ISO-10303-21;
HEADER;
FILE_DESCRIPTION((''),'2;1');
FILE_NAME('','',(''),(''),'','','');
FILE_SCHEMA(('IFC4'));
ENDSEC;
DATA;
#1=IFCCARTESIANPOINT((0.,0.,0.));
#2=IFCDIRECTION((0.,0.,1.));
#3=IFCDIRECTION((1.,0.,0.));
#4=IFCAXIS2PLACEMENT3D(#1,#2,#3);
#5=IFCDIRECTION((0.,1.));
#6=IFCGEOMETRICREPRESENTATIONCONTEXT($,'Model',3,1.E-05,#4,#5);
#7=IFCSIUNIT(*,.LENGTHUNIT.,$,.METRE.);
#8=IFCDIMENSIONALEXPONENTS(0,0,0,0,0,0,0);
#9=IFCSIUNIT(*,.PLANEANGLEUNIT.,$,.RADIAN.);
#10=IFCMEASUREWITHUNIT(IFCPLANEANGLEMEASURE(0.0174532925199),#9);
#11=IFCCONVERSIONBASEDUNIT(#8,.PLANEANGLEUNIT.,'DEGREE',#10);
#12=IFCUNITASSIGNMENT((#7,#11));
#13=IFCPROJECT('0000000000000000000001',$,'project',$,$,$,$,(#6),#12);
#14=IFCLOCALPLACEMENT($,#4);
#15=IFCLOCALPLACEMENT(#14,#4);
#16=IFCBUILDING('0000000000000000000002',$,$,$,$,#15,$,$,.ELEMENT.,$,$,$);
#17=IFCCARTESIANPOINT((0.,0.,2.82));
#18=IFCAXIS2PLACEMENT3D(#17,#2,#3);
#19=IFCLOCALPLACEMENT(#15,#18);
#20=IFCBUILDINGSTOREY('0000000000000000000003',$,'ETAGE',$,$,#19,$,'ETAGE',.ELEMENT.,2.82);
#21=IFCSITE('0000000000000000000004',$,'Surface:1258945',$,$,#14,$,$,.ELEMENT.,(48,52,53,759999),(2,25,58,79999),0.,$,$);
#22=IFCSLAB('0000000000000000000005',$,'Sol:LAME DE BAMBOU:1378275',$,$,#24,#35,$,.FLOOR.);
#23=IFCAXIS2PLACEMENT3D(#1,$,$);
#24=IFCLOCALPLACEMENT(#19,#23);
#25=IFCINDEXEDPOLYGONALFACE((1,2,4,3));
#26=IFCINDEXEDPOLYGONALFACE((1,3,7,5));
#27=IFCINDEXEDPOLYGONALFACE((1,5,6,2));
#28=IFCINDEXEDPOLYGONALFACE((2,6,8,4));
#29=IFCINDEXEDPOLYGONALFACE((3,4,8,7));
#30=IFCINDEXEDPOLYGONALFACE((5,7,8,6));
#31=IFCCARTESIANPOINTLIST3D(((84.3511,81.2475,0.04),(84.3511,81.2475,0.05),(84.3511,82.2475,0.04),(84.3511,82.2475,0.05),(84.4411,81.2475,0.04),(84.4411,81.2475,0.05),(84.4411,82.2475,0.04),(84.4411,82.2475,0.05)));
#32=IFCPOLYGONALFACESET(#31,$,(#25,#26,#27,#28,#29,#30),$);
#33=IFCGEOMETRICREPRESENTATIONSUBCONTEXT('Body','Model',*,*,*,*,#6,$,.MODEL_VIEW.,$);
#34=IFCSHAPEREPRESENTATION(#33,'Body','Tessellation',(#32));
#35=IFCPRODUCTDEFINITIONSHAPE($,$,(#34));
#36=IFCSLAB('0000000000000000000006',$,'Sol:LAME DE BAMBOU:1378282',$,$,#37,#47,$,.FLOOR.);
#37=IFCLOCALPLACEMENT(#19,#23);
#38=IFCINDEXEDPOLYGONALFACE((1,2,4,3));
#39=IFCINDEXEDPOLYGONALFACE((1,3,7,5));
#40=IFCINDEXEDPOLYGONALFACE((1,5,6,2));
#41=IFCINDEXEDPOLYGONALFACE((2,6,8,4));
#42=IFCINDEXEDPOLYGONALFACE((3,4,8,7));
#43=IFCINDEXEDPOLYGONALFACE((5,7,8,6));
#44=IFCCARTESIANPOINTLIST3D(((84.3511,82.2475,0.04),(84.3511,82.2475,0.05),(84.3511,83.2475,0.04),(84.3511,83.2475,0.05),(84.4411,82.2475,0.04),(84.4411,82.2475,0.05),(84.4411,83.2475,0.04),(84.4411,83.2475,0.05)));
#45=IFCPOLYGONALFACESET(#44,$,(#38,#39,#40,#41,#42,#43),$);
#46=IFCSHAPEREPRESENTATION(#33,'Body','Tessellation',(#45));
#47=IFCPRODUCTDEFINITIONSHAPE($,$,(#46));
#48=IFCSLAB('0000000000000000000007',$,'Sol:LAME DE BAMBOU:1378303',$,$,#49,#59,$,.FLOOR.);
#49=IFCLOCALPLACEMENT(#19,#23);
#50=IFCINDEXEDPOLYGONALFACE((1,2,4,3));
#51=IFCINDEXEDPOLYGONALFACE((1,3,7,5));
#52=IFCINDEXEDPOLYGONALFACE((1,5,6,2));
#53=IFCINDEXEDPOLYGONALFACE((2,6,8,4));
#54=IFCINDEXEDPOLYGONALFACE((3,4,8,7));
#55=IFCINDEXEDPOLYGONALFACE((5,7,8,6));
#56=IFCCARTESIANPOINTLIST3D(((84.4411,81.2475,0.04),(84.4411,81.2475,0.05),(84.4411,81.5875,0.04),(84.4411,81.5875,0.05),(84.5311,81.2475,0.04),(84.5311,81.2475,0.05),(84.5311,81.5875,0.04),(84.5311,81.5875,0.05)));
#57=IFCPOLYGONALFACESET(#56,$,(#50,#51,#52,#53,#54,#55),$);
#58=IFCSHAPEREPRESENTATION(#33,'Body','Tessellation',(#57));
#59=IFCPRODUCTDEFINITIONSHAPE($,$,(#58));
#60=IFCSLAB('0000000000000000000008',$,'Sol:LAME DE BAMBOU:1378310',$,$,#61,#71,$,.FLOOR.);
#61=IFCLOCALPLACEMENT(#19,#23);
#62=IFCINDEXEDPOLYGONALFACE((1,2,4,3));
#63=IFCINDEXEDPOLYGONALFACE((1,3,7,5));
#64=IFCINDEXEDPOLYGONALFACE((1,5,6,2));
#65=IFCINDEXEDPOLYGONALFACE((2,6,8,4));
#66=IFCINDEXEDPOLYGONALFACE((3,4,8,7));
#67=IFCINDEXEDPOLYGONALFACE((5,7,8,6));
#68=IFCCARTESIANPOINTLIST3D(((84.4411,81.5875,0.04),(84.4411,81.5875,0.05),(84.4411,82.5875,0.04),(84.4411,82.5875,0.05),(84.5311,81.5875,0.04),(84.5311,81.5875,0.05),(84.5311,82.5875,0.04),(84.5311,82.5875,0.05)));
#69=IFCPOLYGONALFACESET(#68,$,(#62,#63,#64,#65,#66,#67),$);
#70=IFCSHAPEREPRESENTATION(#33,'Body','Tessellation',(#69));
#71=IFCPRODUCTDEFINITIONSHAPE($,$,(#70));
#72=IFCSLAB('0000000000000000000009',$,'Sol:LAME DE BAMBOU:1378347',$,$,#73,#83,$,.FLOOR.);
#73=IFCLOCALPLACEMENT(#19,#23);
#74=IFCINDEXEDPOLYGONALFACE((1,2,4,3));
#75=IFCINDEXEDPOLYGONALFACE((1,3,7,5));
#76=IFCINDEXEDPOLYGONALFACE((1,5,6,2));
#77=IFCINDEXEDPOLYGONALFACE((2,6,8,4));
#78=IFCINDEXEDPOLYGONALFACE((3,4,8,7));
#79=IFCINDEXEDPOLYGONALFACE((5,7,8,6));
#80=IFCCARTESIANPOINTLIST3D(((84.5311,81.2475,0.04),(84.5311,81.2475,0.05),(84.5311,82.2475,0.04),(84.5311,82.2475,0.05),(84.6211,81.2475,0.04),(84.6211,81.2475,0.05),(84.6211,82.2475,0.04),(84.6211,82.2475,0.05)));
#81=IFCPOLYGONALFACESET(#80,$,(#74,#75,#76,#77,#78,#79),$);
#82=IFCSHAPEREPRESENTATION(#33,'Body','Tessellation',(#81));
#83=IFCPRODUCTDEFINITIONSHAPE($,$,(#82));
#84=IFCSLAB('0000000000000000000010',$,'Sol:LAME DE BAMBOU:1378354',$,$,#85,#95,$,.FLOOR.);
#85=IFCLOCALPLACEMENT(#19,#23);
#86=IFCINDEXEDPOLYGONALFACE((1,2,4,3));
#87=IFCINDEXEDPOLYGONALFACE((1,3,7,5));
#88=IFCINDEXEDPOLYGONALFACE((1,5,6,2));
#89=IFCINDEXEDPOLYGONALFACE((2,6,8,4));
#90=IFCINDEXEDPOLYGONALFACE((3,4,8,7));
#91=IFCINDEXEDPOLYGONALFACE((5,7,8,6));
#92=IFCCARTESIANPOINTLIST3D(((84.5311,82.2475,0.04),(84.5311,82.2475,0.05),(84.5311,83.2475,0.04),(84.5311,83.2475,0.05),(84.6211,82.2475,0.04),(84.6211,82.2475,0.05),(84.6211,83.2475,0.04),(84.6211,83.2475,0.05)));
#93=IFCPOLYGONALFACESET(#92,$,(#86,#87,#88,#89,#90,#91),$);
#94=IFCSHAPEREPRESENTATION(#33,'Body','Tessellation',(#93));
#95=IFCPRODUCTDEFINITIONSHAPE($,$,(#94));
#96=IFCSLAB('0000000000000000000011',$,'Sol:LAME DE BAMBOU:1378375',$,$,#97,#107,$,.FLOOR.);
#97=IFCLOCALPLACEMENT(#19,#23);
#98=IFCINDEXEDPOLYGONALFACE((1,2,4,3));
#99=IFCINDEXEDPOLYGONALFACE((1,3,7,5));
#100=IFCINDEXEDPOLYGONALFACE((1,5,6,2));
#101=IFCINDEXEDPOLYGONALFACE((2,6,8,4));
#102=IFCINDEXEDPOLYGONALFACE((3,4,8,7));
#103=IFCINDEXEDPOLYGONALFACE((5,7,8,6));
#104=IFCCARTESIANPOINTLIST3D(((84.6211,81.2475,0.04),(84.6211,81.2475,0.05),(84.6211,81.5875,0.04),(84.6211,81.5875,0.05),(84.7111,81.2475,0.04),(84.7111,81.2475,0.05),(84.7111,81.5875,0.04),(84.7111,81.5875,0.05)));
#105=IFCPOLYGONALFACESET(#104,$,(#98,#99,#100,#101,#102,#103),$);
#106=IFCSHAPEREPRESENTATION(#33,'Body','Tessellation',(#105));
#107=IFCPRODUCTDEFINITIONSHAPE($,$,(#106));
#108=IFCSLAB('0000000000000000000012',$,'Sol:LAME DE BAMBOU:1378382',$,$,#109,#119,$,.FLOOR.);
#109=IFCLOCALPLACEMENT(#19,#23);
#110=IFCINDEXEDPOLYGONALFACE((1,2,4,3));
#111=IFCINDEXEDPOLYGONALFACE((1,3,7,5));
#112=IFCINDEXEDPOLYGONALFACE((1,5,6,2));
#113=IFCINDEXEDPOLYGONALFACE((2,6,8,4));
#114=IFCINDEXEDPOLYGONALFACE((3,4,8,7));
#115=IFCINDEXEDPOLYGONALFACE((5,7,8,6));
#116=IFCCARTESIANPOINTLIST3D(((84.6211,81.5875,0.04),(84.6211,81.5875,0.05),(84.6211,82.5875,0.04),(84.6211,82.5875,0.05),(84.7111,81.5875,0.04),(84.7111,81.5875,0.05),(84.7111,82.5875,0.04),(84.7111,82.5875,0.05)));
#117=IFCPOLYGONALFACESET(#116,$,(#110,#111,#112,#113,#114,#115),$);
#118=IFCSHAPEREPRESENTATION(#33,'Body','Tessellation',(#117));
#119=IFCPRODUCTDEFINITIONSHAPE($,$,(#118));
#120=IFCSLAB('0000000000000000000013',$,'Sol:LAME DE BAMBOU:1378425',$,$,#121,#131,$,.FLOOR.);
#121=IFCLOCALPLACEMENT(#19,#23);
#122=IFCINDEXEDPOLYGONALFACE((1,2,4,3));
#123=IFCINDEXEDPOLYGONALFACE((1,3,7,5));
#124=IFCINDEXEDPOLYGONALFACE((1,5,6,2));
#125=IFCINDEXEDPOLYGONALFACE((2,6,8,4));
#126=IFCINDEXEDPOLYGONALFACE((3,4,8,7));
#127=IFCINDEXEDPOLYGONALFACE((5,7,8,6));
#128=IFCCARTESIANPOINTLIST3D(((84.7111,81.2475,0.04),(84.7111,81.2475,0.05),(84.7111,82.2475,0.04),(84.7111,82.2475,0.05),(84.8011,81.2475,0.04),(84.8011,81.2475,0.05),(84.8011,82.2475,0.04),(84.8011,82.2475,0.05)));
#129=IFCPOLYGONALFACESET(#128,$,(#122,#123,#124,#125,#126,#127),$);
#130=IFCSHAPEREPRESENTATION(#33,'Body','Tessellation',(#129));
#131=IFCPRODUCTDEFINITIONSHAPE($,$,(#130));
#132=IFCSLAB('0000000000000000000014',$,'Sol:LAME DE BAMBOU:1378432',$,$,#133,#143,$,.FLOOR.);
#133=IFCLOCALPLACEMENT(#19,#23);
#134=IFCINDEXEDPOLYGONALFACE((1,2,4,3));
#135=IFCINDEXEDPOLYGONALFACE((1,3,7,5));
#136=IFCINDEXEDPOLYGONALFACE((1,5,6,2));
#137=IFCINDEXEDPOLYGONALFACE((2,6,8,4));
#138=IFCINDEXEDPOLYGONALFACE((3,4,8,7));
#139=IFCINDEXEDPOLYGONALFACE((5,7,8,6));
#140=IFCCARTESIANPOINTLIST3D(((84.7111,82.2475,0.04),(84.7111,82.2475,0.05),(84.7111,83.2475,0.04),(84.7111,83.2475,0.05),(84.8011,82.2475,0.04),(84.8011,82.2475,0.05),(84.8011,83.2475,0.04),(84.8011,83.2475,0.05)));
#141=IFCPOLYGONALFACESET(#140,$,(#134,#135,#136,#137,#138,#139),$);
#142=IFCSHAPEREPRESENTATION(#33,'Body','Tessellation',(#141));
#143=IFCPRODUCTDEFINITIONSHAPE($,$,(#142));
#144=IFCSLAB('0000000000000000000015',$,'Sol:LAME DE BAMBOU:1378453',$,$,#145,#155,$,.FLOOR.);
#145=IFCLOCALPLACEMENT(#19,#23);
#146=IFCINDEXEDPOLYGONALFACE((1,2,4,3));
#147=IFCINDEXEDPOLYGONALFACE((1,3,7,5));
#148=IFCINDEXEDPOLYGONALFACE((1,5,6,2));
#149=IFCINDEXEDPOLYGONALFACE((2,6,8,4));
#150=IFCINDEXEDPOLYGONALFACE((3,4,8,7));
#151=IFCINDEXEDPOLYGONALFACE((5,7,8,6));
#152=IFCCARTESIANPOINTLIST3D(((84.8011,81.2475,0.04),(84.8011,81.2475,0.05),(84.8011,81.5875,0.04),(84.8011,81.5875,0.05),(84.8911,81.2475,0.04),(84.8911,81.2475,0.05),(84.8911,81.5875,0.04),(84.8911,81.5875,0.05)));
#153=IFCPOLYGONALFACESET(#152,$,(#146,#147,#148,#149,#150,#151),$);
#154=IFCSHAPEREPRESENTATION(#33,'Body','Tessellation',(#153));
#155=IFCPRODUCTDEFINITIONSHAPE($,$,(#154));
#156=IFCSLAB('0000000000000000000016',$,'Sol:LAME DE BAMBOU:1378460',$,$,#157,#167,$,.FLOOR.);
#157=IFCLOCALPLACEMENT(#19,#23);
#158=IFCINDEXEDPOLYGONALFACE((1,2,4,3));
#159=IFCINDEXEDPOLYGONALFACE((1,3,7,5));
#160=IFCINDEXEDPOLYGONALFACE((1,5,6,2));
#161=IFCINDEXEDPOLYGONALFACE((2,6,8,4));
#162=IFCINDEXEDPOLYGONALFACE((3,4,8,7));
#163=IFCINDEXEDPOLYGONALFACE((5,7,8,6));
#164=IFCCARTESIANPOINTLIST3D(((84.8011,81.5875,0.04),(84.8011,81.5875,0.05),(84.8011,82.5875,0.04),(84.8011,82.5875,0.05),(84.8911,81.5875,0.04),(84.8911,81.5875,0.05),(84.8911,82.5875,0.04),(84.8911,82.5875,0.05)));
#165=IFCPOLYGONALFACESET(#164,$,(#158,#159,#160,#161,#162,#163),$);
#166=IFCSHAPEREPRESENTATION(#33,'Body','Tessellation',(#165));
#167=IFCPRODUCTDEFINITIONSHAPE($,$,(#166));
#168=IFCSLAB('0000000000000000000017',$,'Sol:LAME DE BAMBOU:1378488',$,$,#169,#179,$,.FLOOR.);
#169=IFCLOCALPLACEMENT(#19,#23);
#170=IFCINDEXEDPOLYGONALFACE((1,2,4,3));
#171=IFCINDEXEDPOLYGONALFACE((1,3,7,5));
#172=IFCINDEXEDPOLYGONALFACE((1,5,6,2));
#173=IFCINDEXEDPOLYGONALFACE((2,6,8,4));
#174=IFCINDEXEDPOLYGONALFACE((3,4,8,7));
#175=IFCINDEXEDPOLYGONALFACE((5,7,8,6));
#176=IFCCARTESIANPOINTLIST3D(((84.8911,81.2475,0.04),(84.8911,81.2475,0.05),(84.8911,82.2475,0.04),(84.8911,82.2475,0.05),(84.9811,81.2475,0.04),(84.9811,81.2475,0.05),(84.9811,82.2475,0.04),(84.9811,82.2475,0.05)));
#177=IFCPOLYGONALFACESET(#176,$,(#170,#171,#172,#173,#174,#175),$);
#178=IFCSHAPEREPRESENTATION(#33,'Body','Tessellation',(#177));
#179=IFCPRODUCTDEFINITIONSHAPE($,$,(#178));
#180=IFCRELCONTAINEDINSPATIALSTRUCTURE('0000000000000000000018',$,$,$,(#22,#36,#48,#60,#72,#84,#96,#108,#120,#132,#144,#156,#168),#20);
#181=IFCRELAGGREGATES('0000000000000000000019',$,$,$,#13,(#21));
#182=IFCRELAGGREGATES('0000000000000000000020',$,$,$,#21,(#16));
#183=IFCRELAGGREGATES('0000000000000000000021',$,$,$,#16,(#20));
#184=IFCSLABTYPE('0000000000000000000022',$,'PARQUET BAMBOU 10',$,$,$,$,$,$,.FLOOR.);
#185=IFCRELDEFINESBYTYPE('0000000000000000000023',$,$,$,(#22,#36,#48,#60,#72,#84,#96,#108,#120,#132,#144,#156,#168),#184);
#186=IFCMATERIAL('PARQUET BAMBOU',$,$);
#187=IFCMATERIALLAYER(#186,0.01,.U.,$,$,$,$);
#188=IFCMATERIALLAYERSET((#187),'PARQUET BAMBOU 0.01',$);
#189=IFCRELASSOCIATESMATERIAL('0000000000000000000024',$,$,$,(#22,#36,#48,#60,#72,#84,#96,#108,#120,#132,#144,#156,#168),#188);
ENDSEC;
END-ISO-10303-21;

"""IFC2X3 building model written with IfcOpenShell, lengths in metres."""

from ifc_helpers import new_model, entity, si_unit, converted_unit, direction, frame, origin_with_axes, place, context, subcontext, project, spatial, polyline, outline, extrude, material, layer, layer_set, layer_usage, type_object, element, save


model = new_model("IFC2X3")

# Units and contexts
model_context = context("Model", 3, precision=1e-05, world=origin_with_axes(), true_north=direction((0.0, 1.0)))
body_context = subcontext(model_context, "Body", "Model", "MODEL_VIEW")
ifc_project = project(units=[si_unit("LENGTHUNIT", "METRE"), converted_unit("PLANEANGLEUNIT", "DEGREE", entity("IfcPlaneAngleMeasure", 0.0174532925199), si_unit("PLANEANGLEUNIT", "RADIAN"), dimensions=[0, 0, 0, 0, 0, 0, 0])], contexts=[model_context])

# Site, building, storey
site_placement = place(None, origin_with_axes())
site = spatial("IfcSite", under=ifc_project, at=site_placement, Name="Surface:1258945", CompositionType="ELEMENT", RefLatitude=(48, 52, 53, 759999), RefLongitude=(2, 25, 58, 79999), RefElevation=0.0)
building_placement = place(site_placement, origin_with_axes())
building = spatial("IfcBuilding", under=site, at=building_placement, CompositionType="ELEMENT")
storey_placement = place(building_placement, frame((0.0, 0.0, 2.82), z_axis=(0.0, 0.0, 1.0), x_axis=(1.0, 0.0, 0.0)))
storey = spatial("IfcBuildingStorey", under=building, at=storey_placement, Name="ETAGE", LongName="ETAGE", CompositionType="ELEMENT", Elevation=2.82)

# Slabs
ifc_material = material(Name="PARQUET BAMBOU")
ifc_layer = layer(ifc_material, 0.01, ventilated="UNKNOWN")
ifc_layer_set = layer_set([ifc_layer], Name="PARQUET BAMBOU 0.01")
ifc_layer_usage_1 = layer_usage(ifc_layer_set, "AXIS3", "NEGATIVE", 0.01)
slab_type = type_object("IfcSlabType", Name="PARQUET BAMBOU 10", PredefinedType="FLOOR")
slab_1_placement = place(storey_placement, frame((84.3511, 82.2475, 0.05), z_axis=(0.0, 0.0, 1.0), x_axis=(1.0, 0.0, 0.0)))
element("IfcSlab", 1, at=slab_1_placement, inside=storey, type_object=slab_type, material=ifc_layer_usage_1, Name="Sol:LAME DE BAMBOU:1378275", PredefinedType="FLOOR", context=body_context, shape_type="SweptSolid", body=[
    extrude(outline(polyline([(0.0, 0.0), (0.0, -1.0), (0.09, -1.0), (0.09, 0.0), (0.0, 0.0)])), frame((0.0, 0.0, -0.01), z_axis=(0.0, 0.0, 1.0), x_axis=(1.0, 0.0, 0.0)), (0.0, 0.0, 1.0), 0.01),
])
ifc_layer_usage_2 = layer_usage(ifc_layer_set, "AXIS3", "NEGATIVE", 0.01)
slab_2_placement = place(storey_placement, frame((84.3511, 83.2475, 0.05), z_axis=(0.0, 0.0, 1.0), x_axis=(1.0, 0.0, 0.0)))
element("IfcSlab", 2, at=slab_2_placement, inside=storey, type_object=slab_type, material=ifc_layer_usage_2, Name="Sol:LAME DE BAMBOU:1378282", PredefinedType="FLOOR", context=body_context, shape_type="SweptSolid", body=[
    extrude(outline(polyline([(0.0, 0.0), (0.0, -1.0), (0.09, -1.0), (0.09, 0.0), (0.0, 0.0)])), frame((0.0, 0.0, -0.01), z_axis=(0.0, 0.0, 1.0), x_axis=(1.0, 0.0, 0.0)), (0.0, 0.0, 1.0), 0.01),
])
ifc_layer_usage_3 = layer_usage(ifc_layer_set, "AXIS3", "NEGATIVE", 0.01)
slab_3_placement = place(storey_placement, frame((84.4411, 81.5875, 0.05), z_axis=(0.0, 0.0, 1.0), x_axis=(1.0, 0.0, 0.0)))
element("IfcSlab", 3, at=slab_3_placement, inside=storey, type_object=slab_type, material=ifc_layer_usage_3, Name="Sol:LAME DE BAMBOU:1378303", PredefinedType="FLOOR", context=body_context, shape_type="SweptSolid", body=[
    extrude(outline(polyline([(0.0, 0.0), (0.0, -0.34), (0.09, -0.34), (0.09, 0.0), (0.0, 0.0)])), frame((0.0, 0.0, -0.01), z_axis=(0.0, 0.0, 1.0), x_axis=(1.0, 0.0, 0.0)), (0.0, 0.0, 1.0), 0.01),
])
ifc_layer_usage_4 = layer_usage(ifc_layer_set, "AXIS3", "NEGATIVE", 0.01)
slab_4_placement = place(storey_placement, frame((84.4411, 82.5875, 0.05), z_axis=(0.0, 0.0, 1.0), x_axis=(1.0, 0.0, 0.0)))
element("IfcSlab", 4, at=slab_4_placement, inside=storey, type_object=slab_type, material=ifc_layer_usage_4, Name="Sol:LAME DE BAMBOU:1378310", PredefinedType="FLOOR", context=body_context, shape_type="SweptSolid", body=[
    extrude(outline(polyline([(0.0, 0.0), (0.0, -1.0), (0.09, -1.0), (0.09, 0.0), (0.0, 0.0)])), frame((0.0, 0.0, -0.01), z_axis=(0.0, 0.0, 1.0), x_axis=(1.0, 0.0, 0.0)), (0.0, 0.0, 1.0), 0.01),
])
ifc_layer_usage_5 = layer_usage(ifc_layer_set, "AXIS3", "NEGATIVE", 0.01)
slab_5_placement = place(storey_placement, frame((84.5311, 82.2475, 0.05), z_axis=(0.0, 0.0, 1.0), x_axis=(1.0, 0.0, 0.0)))
element("IfcSlab", 5, at=slab_5_placement, inside=storey, type_object=slab_type, material=ifc_layer_usage_5, Name="Sol:LAME DE BAMBOU:1378347", PredefinedType="FLOOR", context=body_context, shape_type="SweptSolid", body=[
    extrude(outline(polyline([(0.0, 0.0), (0.0, -1.0), (0.09, -1.0), (0.09, 0.0), (0.0, 0.0)])), frame((0.0, 0.0, -0.01), z_axis=(0.0, 0.0, 1.0), x_axis=(1.0, 0.0, 0.0)), (0.0, 0.0, 1.0), 0.01),
])
ifc_layer_usage_6 = layer_usage(ifc_layer_set, "AXIS3", "NEGATIVE", 0.01)
slab_6_placement = place(storey_placement, frame((84.5311, 83.2475, 0.05), z_axis=(0.0, 0.0, 1.0), x_axis=(1.0, 0.0, 0.0)))
element("IfcSlab", 6, at=slab_6_placement, inside=storey, type_object=slab_type, material=ifc_layer_usage_6, Name="Sol:LAME DE BAMBOU:1378354", PredefinedType="FLOOR", context=body_context, shape_type="SweptSolid", body=[
    extrude(outline(polyline([(0.0, 0.0), (0.0, -1.0), (0.09, -1.0), (0.09, 0.0), (0.0, 0.0)])), frame((0.0, 0.0, -0.01), z_axis=(0.0, 0.0, 1.0), x_axis=(1.0, 0.0, 0.0)), (0.0, 0.0, 1.0), 0.01),
])
ifc_layer_usage_7 = layer_usage(ifc_layer_set, "AXIS3", "NEGATIVE", 0.01)
slab_7_placement = place(storey_placement, frame((84.6211, 81.5875, 0.05), z_axis=(0.0, 0.0, 1.0), x_axis=(1.0, 0.0, 0.0)))
element("IfcSlab", 7, at=slab_7_placement, inside=storey, type_object=slab_type, material=ifc_layer_usage_7, Name="Sol:LAME DE BAMBOU:1378375", PredefinedType="FLOOR", context=body_context, shape_type="SweptSolid", body=[
    extrude(outline(polyline([(0.0, 0.0), (0.0, -0.34), (0.09, -0.34), (0.09, 0.0), (0.0, 0.0)])), frame((0.0, 0.0, -0.01), z_axis=(0.0, 0.0, 1.0), x_axis=(1.0, 0.0, 0.0)), (0.0, 0.0, 1.0), 0.01),
])
ifc_layer_usage_8 = layer_usage(ifc_layer_set, "AXIS3", "NEGATIVE", 0.01)
slab_8_placement = place(storey_placement, frame((84.6211, 82.5875, 0.05), z_axis=(0.0, 0.0, 1.0), x_axis=(1.0, 0.0, 0.0)))
element("IfcSlab", 8, at=slab_8_placement, inside=storey, type_object=slab_type, material=ifc_layer_usage_8, Name="Sol:LAME DE BAMBOU:1378382", PredefinedType="FLOOR", context=body_context, shape_type="SweptSolid", body=[
    extrude(outline(polyline([(0.0, 0.0), (0.0, -1.0), (0.09, -1.0), (0.09, 0.0), (0.0, 0.0)])), frame((0.0, 0.0, -0.01), z_axis=(0.0, 0.0, 1.0), x_axis=(1.0, 0.0, 0.0)), (0.0, 0.0, 1.0), 0.01),
])
ifc_layer_usage_9 = layer_usage(ifc_layer_set, "AXIS3", "NEGATIVE", 0.01)
slab_9_placement = place(storey_placement, frame((84.7111, 82.2475, 0.05), z_axis=(0.0, 0.0, 1.0), x_axis=(1.0, 0.0, 0.0)))
element("IfcSlab", 9, at=slab_9_placement, inside=storey, type_object=slab_type, material=ifc_layer_usage_9, Name="Sol:LAME DE BAMBOU:1378425", PredefinedType="FLOOR", context=body_context, shape_type="SweptSolid", body=[
    extrude(outline(polyline([(0.0, 0.0), (0.0, -1.0), (0.09, -1.0), (0.09, 0.0), (0.0, 0.0)])), frame((0.0, 0.0, -0.01), z_axis=(0.0, 0.0, 1.0), x_axis=(1.0, 0.0, 0.0)), (0.0, 0.0, 1.0), 0.01),
])
ifc_layer_usage_10 = layer_usage(ifc_layer_set, "AXIS3", "NEGATIVE", 0.01)
slab_10_placement = place(storey_placement, frame((84.7111, 83.2475, 0.05), z_axis=(0.0, 0.0, 1.0), x_axis=(1.0, 0.0, 0.0)))
element("IfcSlab", 10, at=slab_10_placement, inside=storey, type_object=slab_type, material=ifc_layer_usage_10, Name="Sol:LAME DE BAMBOU:1378432", PredefinedType="FLOOR", context=body_context, shape_type="SweptSolid", body=[
    extrude(outline(polyline([(0.0, 0.0), (0.0, -1.0), (0.09, -1.0), (0.09, 0.0), (0.0, 0.0)])), frame((0.0, 0.0, -0.01), z_axis=(0.0, 0.0, 1.0), x_axis=(1.0, 0.0, 0.0)), (0.0, 0.0, 1.0), 0.01),
])
ifc_layer_usage_11 = layer_usage(ifc_layer_set, "AXIS3", "NEGATIVE", 0.01)
slab_11_placement = place(storey_placement, frame((84.8011, 81.5875, 0.05), z_axis=(0.0, 0.0, 1.0), x_axis=(1.0, 0.0, 0.0)))
element("IfcSlab", 11, at=slab_11_placement, inside=storey, type_object=slab_type, material=ifc_layer_usage_11, Name="Sol:LAME DE BAMBOU:1378453", PredefinedType="FLOOR", context=body_context, shape_type="SweptSolid", body=[
    extrude(outline(polyline([(0.0, 0.0), (0.0, -0.34), (0.09, -0.34), (0.09, 0.0), (0.0, 0.0)])), frame((0.0, 0.0, -0.01), z_axis=(0.0, 0.0, 1.0), x_axis=(1.0, 0.0, 0.0)), (0.0, 0.0, 1.0), 0.01),
])
ifc_layer_usage_12 = layer_usage(ifc_layer_set, "AXIS3", "NEGATIVE", 0.01)
slab_12_placement = place(storey_placement, frame((84.8011, 82.5875, 0.05), z_axis=(0.0, 0.0, 1.0), x_axis=(1.0, 0.0, 0.0)))
element("IfcSlab", 12, at=slab_12_placement, inside=storey, type_object=slab_type, material=ifc_layer_usage_12, Name="Sol:LAME DE BAMBOU:1378460", PredefinedType="FLOOR", context=body_context, shape_type="SweptSolid", body=[
    extrude(outline(polyline([(0.0, 0.0), (0.0, -1.0), (0.09, -1.0), (0.09, 0.0), (0.0, 0.0)])), frame((0.0, 0.0, -0.01), z_axis=(0.0, 0.0, 1.0), x_axis=(1.0, 0.0, 0.0)), (0.0, 0.0, 1.0), 0.01),
])
ifc_layer_usage_13 = layer_usage(ifc_layer_set, "AXIS3", "NEGATIVE", 0.01)
slab_13_placement = place(storey_placement, frame((84.8911, 82.2475, 0.05), z_axis=(0.0, 0.0, 1.0), x_axis=(1.0, 0.0, 0.0)))
element("IfcSlab", 13, at=slab_13_placement, inside=storey, type_object=slab_type, material=ifc_layer_usage_13, Name="Sol:LAME DE BAMBOU:1378488", PredefinedType="FLOOR", context=body_context, shape_type="SweptSolid", body=[
    extrude(outline(polyline([(0.0, 0.0), (0.0, -1.0), (0.09, -1.0), (0.09, 0.0), (0.0, 0.0)])), frame((0.0, 0.0, -0.01), z_axis=(0.0, 0.0, 1.0), x_axis=(1.0, 0.0, 0.0)), (0.0, 0.0, 1.0), 0.01),
])

save(model, "model.ifc")
